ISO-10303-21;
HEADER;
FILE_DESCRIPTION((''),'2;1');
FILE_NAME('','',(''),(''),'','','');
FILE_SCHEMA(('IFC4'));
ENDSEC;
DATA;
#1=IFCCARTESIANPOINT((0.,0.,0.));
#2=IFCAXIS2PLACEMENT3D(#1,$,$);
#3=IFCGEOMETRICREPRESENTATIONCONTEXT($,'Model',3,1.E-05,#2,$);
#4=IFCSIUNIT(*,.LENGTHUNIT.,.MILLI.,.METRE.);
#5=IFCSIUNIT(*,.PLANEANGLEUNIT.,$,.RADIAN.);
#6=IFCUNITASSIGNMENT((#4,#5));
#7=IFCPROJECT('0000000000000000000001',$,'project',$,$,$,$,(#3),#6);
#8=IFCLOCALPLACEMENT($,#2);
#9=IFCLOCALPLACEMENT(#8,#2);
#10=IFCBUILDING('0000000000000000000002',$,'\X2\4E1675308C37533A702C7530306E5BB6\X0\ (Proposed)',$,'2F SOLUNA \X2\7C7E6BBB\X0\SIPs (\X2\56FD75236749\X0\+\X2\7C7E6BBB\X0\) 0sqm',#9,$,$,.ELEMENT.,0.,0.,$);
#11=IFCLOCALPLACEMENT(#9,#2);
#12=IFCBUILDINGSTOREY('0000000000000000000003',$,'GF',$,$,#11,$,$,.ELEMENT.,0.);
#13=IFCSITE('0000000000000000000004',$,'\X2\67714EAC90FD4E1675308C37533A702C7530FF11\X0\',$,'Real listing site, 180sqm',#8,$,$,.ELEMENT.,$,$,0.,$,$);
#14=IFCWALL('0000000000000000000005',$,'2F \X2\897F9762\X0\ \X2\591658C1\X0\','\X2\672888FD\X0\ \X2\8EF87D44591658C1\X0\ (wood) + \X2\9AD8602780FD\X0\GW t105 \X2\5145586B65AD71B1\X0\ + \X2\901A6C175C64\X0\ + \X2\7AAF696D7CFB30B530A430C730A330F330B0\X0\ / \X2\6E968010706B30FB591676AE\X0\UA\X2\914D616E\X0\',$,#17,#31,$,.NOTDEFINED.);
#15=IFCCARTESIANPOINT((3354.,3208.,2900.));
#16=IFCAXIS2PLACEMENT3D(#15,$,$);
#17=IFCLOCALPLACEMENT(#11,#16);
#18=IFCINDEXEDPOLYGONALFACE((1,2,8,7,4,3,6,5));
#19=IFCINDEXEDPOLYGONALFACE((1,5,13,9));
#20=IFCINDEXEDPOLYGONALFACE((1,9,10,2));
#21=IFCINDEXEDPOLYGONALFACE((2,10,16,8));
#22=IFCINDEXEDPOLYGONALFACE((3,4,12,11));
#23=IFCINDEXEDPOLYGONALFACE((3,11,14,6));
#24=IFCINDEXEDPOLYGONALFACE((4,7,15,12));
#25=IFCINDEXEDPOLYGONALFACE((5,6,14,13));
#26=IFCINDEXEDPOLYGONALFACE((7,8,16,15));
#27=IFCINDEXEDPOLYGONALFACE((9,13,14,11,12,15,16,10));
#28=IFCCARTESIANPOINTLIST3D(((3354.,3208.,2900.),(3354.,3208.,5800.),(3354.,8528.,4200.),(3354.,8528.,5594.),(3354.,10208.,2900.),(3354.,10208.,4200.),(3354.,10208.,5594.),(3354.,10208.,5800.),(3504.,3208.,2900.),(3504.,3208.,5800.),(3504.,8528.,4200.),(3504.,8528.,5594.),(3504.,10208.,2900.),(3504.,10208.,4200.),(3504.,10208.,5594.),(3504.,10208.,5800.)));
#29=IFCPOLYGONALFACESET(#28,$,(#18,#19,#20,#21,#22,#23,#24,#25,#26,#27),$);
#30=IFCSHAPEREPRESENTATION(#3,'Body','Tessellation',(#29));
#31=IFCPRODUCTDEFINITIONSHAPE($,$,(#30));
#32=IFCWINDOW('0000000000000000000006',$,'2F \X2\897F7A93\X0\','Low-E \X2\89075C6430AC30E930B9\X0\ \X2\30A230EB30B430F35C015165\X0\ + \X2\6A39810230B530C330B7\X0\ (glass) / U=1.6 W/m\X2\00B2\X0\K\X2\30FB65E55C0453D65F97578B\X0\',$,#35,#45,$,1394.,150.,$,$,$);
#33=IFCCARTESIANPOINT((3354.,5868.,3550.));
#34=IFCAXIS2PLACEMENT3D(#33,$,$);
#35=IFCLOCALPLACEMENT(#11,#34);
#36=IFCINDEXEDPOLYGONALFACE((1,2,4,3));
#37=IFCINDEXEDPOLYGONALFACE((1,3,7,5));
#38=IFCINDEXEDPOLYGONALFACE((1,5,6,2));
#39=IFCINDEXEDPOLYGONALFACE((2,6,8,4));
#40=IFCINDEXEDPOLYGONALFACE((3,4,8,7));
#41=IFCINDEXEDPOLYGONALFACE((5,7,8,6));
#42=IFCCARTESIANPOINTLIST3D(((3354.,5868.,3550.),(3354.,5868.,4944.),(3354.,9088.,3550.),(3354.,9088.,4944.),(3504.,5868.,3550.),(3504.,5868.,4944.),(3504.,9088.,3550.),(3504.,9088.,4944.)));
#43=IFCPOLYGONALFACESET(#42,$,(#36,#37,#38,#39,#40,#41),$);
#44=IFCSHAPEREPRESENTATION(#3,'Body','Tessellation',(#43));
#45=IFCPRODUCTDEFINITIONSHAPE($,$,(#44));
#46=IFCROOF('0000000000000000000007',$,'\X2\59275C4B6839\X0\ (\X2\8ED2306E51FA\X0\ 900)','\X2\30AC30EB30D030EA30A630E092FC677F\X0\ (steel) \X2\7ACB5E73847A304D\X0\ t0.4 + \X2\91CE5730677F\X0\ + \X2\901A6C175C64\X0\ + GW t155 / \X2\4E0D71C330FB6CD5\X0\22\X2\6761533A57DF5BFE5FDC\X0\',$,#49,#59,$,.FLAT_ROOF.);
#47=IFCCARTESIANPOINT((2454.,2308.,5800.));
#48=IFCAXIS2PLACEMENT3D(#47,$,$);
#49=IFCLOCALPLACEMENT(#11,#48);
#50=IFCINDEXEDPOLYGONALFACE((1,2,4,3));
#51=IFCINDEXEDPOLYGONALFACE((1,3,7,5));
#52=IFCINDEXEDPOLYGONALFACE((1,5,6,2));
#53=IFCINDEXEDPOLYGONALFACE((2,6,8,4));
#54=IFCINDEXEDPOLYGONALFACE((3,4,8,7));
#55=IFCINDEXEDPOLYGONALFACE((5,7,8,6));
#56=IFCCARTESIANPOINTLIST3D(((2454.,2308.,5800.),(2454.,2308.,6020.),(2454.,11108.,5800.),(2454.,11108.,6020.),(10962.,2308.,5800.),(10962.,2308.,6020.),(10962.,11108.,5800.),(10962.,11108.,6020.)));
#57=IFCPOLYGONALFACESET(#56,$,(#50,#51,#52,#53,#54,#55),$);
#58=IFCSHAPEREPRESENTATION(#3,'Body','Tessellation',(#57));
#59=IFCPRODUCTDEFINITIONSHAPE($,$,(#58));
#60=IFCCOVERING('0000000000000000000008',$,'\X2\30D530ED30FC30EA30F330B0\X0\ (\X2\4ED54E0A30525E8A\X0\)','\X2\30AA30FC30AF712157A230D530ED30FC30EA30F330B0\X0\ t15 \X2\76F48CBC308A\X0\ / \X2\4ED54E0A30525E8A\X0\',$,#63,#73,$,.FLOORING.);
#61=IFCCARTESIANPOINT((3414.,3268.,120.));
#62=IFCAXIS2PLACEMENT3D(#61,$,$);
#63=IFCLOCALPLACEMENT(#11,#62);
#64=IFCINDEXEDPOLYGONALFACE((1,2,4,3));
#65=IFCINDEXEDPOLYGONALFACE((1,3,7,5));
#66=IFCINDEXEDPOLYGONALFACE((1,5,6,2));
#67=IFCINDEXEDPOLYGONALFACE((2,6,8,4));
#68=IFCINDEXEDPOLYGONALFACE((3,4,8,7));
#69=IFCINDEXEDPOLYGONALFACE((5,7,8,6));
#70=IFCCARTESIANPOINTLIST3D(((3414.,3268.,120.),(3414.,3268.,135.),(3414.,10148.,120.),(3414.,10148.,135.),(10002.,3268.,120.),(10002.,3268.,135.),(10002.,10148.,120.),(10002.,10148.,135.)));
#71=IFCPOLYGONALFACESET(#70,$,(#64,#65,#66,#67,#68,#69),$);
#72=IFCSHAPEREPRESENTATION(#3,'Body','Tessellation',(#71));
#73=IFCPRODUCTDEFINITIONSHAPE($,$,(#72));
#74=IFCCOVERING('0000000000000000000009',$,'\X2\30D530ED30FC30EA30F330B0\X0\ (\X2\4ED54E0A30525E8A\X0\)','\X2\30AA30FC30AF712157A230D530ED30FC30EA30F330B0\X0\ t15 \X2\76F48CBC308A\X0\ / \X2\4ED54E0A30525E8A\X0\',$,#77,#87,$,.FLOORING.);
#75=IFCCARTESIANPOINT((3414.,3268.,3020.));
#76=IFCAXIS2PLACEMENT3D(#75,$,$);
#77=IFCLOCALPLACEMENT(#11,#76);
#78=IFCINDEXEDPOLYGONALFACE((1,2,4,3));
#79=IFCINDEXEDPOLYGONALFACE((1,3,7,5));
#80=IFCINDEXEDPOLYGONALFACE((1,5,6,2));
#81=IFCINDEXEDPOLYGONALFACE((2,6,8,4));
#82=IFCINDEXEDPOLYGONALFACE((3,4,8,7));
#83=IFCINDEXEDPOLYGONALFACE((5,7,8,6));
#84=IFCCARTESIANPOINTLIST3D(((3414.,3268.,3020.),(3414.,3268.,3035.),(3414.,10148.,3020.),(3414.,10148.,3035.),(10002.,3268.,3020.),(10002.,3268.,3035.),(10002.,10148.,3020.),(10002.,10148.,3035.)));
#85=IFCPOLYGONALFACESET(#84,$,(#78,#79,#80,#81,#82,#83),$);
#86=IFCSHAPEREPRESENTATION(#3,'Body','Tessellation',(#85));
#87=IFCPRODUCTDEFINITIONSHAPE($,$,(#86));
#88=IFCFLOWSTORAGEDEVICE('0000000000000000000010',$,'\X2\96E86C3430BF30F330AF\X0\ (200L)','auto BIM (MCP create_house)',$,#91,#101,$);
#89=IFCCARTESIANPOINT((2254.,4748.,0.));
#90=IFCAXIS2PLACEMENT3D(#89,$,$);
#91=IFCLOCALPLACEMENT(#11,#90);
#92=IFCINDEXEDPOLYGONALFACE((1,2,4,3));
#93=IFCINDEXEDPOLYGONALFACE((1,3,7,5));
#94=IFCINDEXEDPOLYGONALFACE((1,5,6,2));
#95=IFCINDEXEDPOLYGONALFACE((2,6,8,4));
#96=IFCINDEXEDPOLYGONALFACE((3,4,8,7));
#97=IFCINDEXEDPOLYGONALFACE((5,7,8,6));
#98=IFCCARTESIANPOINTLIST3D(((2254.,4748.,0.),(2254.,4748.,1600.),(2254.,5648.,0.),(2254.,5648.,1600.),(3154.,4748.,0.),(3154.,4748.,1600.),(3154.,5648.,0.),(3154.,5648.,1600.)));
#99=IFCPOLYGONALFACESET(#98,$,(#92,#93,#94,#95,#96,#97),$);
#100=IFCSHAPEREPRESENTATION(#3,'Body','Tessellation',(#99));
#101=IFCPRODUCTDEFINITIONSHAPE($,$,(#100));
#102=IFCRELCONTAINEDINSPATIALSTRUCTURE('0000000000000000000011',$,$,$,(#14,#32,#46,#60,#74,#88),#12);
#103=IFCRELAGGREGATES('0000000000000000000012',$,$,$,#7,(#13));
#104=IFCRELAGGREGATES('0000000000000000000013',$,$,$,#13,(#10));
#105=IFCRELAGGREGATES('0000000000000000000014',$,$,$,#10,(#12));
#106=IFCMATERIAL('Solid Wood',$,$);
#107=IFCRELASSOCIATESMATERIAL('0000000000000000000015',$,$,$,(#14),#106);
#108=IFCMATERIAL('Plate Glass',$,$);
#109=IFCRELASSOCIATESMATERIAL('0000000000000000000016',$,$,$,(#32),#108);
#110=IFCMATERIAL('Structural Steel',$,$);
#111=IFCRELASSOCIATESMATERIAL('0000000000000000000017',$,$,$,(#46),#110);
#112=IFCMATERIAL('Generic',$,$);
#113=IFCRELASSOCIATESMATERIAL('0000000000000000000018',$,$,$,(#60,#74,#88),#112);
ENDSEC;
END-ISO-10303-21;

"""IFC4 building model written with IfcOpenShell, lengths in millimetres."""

from ifc_helpers import new_model, si_unit, frame, frame_2d, origin, place, context, project, spatial, rectangle, extrude, material, element, fill, save


model = new_model("IFC4")

# Units and contexts
model_context = context("Model", 3, precision=1e-05, world=origin())
ifc_project = project(units=[si_unit("LENGTHUNIT", "METRE", prefix="MILLI"), si_unit("PLANEANGLEUNIT", "RADIAN")], contexts=[model_context])

# Site, building, storey
site_placement = place(None, origin())
site = spatial("IfcSite", under=ifc_project, at=site_placement, Name="東京都世田谷区瀬田１", ObjectType="Real listing site, 180sqm", CompositionType="ELEMENT", RefElevation=0.0)
building_placement = place(site_placement, origin())
building = spatial("IfcBuilding", under=site, at=building_placement, Name="世田谷区瀬田の家 (Proposed)", ObjectType="2F SOLUNA 籾殻SIPs (国産杉+籾殻) 0sqm", CompositionType="ELEMENT", ElevationOfRefHeight=0.0, ElevationOfTerrain=0.0)
storey_placement = place(building_placement, origin())
storey = spatial("IfcBuildingStorey", under=building, at=storey_placement, Name="GF", CompositionType="ELEMENT", Elevation=0.0)

# Shared definitions
ifc_material_1 = material(Name="Solid Wood")

# Shared definitions
ifc_material_2 = material(Name="Plate Glass")

# Wall, opening, window
wall_1_placement = place(storey_placement, frame((3354.0, 3208.0, 2900.0)))
wall_1 = element("IfcWall", 1, at=wall_1_placement, inside=storey, material=ifc_material_1, Name="2F 西面 外壁", Description="木製 軸組外壁 (wood) + 高性能GW t105 充填断熱 + 通気層 + 窯業系サイディング / 準耐火・外皮UA配慮", PredefinedType="NOTDEFINED", context=model_context, shape_type="SweptSolid", body=[
    extrude(rectangle(XDim=150.0, YDim=7000.0, at=frame_2d((75.0, 3500.0))), frame((3354.0, 3208.0, 2900.0)), (0.0, 0.0, 1.0), 2900.0),
])
opening_1_placement = place(storey_placement, frame((3354.0, 5868.0, 3550.0)))
opening_1 = element("IfcOpeningElement", 2, at=opening_1_placement, cuts=wall_1, PredefinedType="NOTDEFINED", context=model_context, shape_type="SweptSolid", body=[
    extrude(rectangle(XDim=150.0, YDim=3220.0, at=frame_2d((75.0, 1610.0))), frame((3354.0, 5868.0, 3550.0)), (0.0, 0.0, 1.0), 1394.0),
])
window_1_placement = place(storey_placement, frame((3354.0, 5868.0, 3550.0)))
window_1 = element("IfcWindow", 3, at=window_1_placement, inside=storey, material=ifc_material_2, Name="2F 西窓", Description="Low-E 複層ガラス アルゴン封入 + 樹脂サッシ (glass) / U=1.6 W/m²K・日射取得型", OverallHeight=1394.0, OverallWidth=150.0, context=model_context, shape_type="SweptSolid", body=[
    extrude(rectangle(XDim=150.0, YDim=3220.0, at=frame_2d((75.0, 1610.0))), frame((3354.0, 5868.0, 3550.0)), (0.0, 0.0, 1.0), 1394.0),
])
fill(opening_1, window_1)

# Roof
ifc_material_3 = material(Name="Structural Steel")
roof_placement = place(storey_placement, frame((2454.0, 2308.0, 5800.0)))
element("IfcRoof", 4, at=roof_placement, inside=storey, material=ifc_material_3, Name="大屋根 (軒の出 900)", Description="ガルバリウム鋼板 (steel) 立平葺き t0.4 + 野地板 + 通気層 + GW t155 / 不燃・法22条区域対応", PredefinedType="FLAT_ROOF", context=model_context, shape_type="SweptSolid", body=[
    extrude(rectangle(XDim=8508.0, YDim=8800.0, at=frame_2d((4254.0, 4400.0))), frame((2454.0, 2308.0, 5800.0)), (0.0, 0.0, 1.0), 220.0),
])

# Coverings
ifc_material_4 = material(Name="Generic")
covering_1_placement = place(storey_placement, frame((3414.0, 3268.0, 120.0)))
element("IfcCovering", 5, at=covering_1_placement, inside=storey, material=ifc_material_4, Name="フローリング (仕上げ床)", Description="オーク無垢フローリング t15 直貼り / 仕上げ床", PredefinedType="FLOORING", context=model_context, shape_type="SweptSolid", body=[
    extrude(rectangle(XDim=6588.0, YDim=6880.0, at=frame_2d((3294.0, 3440.0))), frame((3414.0, 3268.0, 120.0)), (0.0, 0.0, 1.0), 15.0),
])
covering_2_placement = place(storey_placement, frame((3414.0, 3268.0, 3020.0)))
element("IfcCovering", 6, at=covering_2_placement, inside=storey, material=ifc_material_4, Name="フローリング (仕上げ床)", Description="オーク無垢フローリング t15 直貼り / 仕上げ床", PredefinedType="FLOORING", context=model_context, shape_type="SweptSolid", body=[
    extrude(rectangle(XDim=6588.0, YDim=6880.0, at=frame_2d((3294.0, 3440.0))), frame((3414.0, 3268.0, 3020.0)), (0.0, 0.0, 1.0), 15.0),
])

# Flow storage device
flow_storage_device_placement = place(storey_placement, frame((2254.0, 4748.0, 0.0)))
element("IfcFlowStorageDevice", 7, at=flow_storage_device_placement, inside=storey, material=ifc_material_4, Name="雨水タンク (200L)", Description="auto BIM (MCP create_house)", context=model_context, shape_type="SweptSolid", body=[
    extrude(rectangle(XDim=900.0, YDim=900.0, at=frame_2d((450.0, 450.0))), frame((2254.0, 4748.0, 0.0)), (0.0, 0.0, 1.0), 1600.0),
])

save(model, "model.ifc")
